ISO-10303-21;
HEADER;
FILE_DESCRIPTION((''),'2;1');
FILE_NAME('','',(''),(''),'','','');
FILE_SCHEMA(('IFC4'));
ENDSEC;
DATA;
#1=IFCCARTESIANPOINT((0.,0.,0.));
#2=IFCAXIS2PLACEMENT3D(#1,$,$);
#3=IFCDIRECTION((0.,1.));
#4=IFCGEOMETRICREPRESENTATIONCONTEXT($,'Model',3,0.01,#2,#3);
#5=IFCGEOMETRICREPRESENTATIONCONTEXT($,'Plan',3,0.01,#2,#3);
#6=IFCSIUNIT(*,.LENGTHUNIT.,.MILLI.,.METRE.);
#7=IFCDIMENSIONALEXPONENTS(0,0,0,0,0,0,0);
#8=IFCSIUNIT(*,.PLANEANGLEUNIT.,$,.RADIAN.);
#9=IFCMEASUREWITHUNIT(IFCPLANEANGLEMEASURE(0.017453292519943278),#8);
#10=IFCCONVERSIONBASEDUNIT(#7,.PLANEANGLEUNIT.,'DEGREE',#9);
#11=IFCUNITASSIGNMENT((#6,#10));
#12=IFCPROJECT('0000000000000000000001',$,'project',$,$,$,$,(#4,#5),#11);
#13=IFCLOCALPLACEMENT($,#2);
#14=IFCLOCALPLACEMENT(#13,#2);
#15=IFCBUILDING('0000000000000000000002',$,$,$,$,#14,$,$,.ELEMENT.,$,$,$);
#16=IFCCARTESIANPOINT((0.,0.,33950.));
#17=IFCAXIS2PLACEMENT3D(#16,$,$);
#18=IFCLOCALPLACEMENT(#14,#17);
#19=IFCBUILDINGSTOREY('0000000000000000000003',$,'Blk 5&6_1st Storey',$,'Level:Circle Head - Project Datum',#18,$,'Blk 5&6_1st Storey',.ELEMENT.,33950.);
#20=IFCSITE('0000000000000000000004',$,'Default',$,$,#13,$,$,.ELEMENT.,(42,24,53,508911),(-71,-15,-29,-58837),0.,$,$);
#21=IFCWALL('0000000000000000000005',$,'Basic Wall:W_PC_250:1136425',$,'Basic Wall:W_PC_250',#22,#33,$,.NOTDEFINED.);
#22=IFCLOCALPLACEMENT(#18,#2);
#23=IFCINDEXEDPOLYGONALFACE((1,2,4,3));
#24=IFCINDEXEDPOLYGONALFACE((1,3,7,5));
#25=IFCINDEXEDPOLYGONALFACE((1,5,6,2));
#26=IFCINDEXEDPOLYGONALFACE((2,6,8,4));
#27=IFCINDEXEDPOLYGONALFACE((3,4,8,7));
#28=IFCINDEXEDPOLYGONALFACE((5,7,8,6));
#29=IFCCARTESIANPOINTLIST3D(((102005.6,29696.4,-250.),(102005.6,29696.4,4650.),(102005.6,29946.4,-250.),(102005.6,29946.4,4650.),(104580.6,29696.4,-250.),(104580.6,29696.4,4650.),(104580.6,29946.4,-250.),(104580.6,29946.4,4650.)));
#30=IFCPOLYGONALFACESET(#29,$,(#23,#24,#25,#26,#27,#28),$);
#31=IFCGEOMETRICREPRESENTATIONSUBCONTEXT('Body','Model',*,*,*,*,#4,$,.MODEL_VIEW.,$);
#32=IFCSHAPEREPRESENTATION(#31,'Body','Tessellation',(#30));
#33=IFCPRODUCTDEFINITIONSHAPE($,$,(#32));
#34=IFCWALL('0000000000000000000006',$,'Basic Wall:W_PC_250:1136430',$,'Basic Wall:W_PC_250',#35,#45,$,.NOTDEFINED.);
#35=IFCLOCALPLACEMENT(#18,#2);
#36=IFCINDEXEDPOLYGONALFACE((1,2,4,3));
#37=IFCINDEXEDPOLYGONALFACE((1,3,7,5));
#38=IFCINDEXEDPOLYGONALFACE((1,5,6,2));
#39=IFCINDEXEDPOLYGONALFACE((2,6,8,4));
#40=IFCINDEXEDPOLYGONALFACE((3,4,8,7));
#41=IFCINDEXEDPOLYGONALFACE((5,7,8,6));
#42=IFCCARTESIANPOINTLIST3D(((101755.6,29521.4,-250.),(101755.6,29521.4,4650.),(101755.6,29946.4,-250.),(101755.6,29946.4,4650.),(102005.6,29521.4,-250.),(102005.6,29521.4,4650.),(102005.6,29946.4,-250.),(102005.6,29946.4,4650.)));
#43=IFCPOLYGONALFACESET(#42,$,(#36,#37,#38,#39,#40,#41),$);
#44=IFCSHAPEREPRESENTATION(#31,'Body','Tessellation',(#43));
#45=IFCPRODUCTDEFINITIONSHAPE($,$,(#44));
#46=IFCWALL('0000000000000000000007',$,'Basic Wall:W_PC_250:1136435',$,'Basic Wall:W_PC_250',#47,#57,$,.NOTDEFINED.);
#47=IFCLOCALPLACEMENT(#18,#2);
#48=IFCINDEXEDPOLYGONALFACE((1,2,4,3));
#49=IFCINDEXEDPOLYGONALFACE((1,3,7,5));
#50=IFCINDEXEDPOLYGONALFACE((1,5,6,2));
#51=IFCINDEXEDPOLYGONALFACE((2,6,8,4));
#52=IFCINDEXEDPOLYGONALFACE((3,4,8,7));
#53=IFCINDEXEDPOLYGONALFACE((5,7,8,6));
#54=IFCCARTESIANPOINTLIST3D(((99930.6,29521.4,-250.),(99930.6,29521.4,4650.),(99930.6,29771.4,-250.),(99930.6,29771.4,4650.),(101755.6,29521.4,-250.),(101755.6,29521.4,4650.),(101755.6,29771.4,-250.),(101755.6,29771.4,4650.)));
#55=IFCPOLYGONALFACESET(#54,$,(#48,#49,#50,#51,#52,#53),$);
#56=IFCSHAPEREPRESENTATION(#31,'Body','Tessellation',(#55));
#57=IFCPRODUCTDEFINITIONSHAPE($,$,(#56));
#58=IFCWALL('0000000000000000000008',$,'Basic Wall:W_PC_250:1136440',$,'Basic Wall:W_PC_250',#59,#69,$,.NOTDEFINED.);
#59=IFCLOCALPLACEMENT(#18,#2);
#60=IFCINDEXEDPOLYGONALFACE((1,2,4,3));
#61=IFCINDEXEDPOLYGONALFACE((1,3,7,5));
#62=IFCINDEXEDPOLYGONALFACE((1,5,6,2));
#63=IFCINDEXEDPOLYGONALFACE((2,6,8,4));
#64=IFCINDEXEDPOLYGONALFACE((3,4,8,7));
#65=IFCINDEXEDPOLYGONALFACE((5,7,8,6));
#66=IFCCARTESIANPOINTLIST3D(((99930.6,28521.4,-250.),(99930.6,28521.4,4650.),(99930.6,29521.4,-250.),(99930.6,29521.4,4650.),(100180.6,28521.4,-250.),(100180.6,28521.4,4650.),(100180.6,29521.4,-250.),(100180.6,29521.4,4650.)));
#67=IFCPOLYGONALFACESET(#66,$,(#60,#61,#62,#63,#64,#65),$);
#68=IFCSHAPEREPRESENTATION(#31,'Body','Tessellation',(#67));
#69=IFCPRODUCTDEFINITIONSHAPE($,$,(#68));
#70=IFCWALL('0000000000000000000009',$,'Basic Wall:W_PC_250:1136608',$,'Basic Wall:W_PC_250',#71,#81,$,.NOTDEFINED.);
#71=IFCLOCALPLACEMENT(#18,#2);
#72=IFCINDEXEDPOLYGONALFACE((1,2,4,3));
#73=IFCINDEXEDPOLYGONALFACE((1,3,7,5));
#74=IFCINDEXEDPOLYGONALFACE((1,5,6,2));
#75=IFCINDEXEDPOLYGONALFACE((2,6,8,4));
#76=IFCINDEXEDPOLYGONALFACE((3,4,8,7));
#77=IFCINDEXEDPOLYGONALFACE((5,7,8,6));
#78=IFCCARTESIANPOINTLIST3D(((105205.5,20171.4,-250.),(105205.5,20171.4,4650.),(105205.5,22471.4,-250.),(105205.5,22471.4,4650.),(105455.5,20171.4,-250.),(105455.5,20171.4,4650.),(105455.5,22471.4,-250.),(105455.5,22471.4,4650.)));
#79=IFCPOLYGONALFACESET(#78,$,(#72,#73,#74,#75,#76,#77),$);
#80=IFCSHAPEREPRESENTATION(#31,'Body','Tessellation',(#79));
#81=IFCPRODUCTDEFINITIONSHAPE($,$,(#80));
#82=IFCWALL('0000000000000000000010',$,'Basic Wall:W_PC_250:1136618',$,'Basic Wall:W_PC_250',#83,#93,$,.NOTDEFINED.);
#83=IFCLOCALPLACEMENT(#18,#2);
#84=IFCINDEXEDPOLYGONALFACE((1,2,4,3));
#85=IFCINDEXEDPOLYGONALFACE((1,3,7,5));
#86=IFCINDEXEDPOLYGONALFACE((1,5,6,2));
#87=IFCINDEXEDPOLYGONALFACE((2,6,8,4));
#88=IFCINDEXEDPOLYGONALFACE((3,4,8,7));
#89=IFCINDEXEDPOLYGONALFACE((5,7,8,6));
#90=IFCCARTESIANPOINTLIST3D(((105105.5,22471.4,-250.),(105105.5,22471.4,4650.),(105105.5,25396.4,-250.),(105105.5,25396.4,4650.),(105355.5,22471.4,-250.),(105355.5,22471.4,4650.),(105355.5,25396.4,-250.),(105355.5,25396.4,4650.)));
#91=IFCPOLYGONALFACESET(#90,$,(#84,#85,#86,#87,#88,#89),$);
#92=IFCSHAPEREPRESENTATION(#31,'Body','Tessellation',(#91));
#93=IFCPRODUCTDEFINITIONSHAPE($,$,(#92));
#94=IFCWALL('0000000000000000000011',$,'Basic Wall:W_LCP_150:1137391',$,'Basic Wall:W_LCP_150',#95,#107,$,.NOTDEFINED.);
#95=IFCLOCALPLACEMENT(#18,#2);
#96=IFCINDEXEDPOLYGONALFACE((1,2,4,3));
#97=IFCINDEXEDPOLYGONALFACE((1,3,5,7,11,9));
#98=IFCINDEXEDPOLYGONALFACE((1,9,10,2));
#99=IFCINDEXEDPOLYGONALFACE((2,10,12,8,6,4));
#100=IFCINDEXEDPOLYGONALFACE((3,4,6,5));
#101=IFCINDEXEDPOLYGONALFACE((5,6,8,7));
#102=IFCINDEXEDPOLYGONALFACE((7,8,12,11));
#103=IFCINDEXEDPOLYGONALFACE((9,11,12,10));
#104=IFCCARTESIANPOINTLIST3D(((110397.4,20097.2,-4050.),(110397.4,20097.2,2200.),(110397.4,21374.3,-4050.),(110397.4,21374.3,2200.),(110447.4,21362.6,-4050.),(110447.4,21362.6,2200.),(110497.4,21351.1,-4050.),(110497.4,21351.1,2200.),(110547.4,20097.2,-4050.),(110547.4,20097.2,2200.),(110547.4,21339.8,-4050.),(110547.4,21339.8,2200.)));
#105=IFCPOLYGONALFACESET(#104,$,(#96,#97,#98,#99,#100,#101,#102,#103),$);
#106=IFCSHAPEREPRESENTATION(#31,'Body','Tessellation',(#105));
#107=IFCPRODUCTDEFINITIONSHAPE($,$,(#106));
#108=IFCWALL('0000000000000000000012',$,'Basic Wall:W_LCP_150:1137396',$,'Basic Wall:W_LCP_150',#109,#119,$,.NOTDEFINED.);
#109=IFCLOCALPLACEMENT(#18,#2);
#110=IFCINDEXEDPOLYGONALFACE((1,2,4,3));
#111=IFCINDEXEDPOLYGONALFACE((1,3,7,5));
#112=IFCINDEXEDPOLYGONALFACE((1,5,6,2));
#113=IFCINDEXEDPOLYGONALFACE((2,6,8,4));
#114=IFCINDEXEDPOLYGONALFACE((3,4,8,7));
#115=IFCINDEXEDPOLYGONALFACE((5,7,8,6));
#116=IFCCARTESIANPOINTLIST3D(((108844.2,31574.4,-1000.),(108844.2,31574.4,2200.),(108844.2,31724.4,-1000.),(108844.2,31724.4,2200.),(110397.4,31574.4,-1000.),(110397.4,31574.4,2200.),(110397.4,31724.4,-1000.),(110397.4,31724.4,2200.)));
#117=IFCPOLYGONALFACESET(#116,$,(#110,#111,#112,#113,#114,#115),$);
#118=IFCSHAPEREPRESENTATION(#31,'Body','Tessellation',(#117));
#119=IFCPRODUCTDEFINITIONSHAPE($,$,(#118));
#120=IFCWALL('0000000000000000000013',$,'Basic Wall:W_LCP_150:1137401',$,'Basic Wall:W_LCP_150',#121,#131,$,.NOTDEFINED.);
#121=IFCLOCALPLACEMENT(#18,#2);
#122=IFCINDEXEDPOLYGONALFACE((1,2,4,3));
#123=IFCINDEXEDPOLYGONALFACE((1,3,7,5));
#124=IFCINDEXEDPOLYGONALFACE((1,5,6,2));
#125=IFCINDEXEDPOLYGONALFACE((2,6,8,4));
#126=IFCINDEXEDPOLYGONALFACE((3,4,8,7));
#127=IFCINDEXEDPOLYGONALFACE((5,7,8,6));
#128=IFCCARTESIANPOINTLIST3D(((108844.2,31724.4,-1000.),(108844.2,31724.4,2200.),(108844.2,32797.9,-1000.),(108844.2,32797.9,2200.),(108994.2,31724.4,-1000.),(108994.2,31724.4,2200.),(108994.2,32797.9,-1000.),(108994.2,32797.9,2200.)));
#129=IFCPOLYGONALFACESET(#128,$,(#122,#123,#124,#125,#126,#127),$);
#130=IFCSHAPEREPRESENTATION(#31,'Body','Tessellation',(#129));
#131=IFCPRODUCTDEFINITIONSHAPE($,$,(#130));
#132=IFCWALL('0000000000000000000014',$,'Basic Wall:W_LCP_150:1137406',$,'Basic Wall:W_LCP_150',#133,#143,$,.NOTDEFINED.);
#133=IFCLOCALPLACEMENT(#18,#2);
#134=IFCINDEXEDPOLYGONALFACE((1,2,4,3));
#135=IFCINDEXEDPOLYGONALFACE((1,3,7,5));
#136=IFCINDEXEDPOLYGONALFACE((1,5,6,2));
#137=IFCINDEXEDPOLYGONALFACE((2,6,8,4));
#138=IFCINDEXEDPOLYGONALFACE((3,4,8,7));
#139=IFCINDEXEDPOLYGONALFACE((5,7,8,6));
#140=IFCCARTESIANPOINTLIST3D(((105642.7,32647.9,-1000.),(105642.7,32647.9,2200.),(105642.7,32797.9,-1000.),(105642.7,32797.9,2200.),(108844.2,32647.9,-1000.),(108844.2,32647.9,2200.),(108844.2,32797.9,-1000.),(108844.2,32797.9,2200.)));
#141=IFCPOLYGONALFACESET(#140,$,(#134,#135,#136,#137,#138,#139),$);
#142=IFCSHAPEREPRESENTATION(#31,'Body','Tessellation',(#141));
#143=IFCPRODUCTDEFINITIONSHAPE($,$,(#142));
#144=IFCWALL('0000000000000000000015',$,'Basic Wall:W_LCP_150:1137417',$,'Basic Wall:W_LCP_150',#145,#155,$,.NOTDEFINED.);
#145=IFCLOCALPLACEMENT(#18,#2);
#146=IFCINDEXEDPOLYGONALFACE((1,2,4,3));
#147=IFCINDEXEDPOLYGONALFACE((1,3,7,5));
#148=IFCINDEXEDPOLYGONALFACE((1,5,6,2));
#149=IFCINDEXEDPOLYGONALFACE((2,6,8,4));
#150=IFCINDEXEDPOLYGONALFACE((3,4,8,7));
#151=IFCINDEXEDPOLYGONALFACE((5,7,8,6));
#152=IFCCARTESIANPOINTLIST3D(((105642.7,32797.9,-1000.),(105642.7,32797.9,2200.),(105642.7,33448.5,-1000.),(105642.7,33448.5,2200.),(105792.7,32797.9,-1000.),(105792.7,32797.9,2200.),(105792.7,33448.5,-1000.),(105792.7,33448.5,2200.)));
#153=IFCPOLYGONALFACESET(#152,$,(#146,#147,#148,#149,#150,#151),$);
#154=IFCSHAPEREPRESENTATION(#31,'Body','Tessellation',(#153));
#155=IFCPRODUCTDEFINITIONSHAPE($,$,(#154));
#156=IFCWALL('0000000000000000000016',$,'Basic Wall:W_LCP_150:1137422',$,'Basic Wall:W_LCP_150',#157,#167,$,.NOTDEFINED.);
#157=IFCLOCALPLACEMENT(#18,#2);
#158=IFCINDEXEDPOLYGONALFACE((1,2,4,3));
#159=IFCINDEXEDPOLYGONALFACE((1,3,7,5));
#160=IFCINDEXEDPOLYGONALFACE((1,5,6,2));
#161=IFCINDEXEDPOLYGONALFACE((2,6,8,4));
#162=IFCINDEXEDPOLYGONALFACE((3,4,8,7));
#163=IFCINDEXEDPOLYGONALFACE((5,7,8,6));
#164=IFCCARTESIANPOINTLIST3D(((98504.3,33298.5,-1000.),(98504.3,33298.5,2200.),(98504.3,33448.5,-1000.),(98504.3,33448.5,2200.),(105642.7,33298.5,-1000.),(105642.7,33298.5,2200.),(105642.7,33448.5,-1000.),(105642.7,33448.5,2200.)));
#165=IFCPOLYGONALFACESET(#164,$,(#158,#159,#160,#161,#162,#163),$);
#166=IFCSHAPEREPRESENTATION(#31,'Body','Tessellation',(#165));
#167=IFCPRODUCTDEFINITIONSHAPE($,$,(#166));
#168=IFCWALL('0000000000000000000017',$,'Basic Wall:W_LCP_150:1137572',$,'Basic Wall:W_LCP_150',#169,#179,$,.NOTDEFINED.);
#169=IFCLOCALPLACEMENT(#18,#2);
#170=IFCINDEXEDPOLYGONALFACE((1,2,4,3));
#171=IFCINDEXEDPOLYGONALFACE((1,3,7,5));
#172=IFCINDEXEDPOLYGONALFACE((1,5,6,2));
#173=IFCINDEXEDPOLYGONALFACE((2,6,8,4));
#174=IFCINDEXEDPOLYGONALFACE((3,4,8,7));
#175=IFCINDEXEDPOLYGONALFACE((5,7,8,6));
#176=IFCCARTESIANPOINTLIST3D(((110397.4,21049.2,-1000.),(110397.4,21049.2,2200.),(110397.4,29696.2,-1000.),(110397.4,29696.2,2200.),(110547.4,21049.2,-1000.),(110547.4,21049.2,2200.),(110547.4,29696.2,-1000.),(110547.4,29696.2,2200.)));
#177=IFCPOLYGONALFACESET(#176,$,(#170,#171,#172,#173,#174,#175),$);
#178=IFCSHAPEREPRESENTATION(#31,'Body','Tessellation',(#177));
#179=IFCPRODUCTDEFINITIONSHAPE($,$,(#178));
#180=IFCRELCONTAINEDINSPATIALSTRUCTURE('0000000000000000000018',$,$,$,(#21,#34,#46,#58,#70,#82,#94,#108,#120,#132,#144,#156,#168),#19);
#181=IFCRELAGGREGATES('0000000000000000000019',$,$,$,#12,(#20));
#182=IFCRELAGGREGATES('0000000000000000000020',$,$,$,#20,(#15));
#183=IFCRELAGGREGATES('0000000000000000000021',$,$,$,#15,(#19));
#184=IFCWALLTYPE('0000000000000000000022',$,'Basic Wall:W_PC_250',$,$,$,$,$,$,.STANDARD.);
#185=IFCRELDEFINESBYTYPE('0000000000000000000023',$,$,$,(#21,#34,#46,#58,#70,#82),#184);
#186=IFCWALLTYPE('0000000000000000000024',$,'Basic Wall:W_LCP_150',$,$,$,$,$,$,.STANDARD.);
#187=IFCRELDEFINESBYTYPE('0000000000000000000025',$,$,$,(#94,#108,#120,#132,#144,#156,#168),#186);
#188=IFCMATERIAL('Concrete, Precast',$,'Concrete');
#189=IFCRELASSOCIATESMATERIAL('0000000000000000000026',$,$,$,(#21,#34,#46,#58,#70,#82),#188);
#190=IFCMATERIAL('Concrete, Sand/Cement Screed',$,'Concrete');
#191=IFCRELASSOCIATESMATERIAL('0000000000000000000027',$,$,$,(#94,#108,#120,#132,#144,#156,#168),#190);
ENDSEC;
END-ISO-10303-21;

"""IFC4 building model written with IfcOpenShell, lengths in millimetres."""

from ifc_helpers import new_model, entity, si_unit, converted_unit, direction, frame, origin, place, context, subcontext, project, spatial, line, arc, indexed_curve, outline, extrude, material, type_object, element, save


model = new_model("IFC4")

# Units and contexts
model_context = context("Model", 3, precision=0.01, world=origin(), true_north=direction((0.0, 1.0)))
plan_context = context("Plan", 3, precision=0.01, world=origin(), true_north=direction((0.0, 1.0)))
body_context = subcontext(model_context, "Body", "Model", "MODEL_VIEW")
ifc_project = project(units=[si_unit("LENGTHUNIT", "METRE", prefix="MILLI"), converted_unit("PLANEANGLEUNIT", "DEGREE", entity("IfcPlaneAngleMeasure", 0.017453292519943278), si_unit("PLANEANGLEUNIT", "RADIAN"), dimensions=[0, 0, 0, 0, 0, 0, 0])], contexts=[model_context, plan_context])

# Site, building, storey
site_placement = place(None, origin())
site = spatial("IfcSite", under=ifc_project, at=site_placement, Name="Default", CompositionType="ELEMENT", RefLatitude=(42, 24, 53, 508911), RefLongitude=(-71, -15, -29, -58837), RefElevation=0.0)
building_placement = place(site_placement, origin())
building = spatial("IfcBuilding", under=site, at=building_placement, CompositionType="ELEMENT")
storey_placement = place(building_placement, frame((0.0, 0.0, 33950.0)))
storey = spatial("IfcBuildingStorey", under=building, at=storey_placement, Name="Blk 5&6_1st Storey", ObjectType="Level:Circle Head - Project Datum", LongName="Blk 5&6_1st Storey", CompositionType="ELEMENT", Elevation=33950.0)

# Walls
ifc_material_1 = material(Name="Concrete, Sand/Cement Screed", Category="Concrete")
ifc_material_2 = material(Name="Concrete, Precast", Category="Concrete")
wall_type_1 = type_object("IfcWallType", Name="Basic Wall:W_PC_250", PredefinedType="STANDARD")
wall_1_placement = place(storey_placement, frame((104580.6, 29821.4, -250.0), z_axis=(0.0, 0.0, 1.0), x_axis=(-1.0, 0.0, 0.0)))
element("IfcWall", 1, at=wall_1_placement, inside=storey, type_object=wall_type_1, material=ifc_material_2, Name="Basic Wall:W_PC_250:1136425", ObjectType="Basic Wall:W_PC_250", PredefinedType="NOTDEFINED", context=body_context, shape_type="SweptSolid", body=[
    extrude(outline(indexed_curve([(2575.0, 125.0), (0.0, 125.0), (0.0, -125.0), (2575.0, -125.0), (2575.0, 125.0)], self_intersect=False)), origin(), (0.0, 0.0, 1.0), 4900.0),
])
wall_2_placement = place(storey_placement, frame((101880.6, 29946.4, -250.0), z_axis=(0.0, 0.0, 1.0), x_axis=(0.0, -1.0, 0.0)))
element("IfcWall", 2, at=wall_2_placement, inside=storey, type_object=wall_type_1, material=ifc_material_2, Name="Basic Wall:W_PC_250:1136430", ObjectType="Basic Wall:W_PC_250", PredefinedType="NOTDEFINED", context=body_context, shape_type="SweptSolid", body=[
    extrude(outline(indexed_curve([(425.0, 125.0), (0.0, 125.0), (0.0, -125.0), (425.0, -125.0), (425.0, 125.0)], self_intersect=False)), origin(), (0.0, 0.0, 1.0), 4900.0),
])
wall_3_placement = place(storey_placement, frame((101755.6, 29646.4, -250.0), z_axis=(0.0, 0.0, 1.0), x_axis=(-1.0, 0.0, 0.0)))
element("IfcWall", 3, at=wall_3_placement, inside=storey, type_object=wall_type_1, material=ifc_material_2, Name="Basic Wall:W_PC_250:1136435", ObjectType="Basic Wall:W_PC_250", PredefinedType="NOTDEFINED", context=body_context, shape_type="SweptSolid", body=[
    extrude(outline(indexed_curve([(1825.0, 125.0), (0.0, 125.0), (0.0, -125.0), (1825.0, -125.0), (1825.0, 125.0)], self_intersect=False)), origin(), (0.0, 0.0, 1.0), 4900.0),
])
wall_4_placement = place(storey_placement, frame((100055.6, 29521.4, -250.0), z_axis=(0.0, 0.0, 1.0), x_axis=(0.0, -1.0, 0.0)))
element("IfcWall", 4, at=wall_4_placement, inside=storey, type_object=wall_type_1, material=ifc_material_2, Name="Basic Wall:W_PC_250:1136440", ObjectType="Basic Wall:W_PC_250", PredefinedType="NOTDEFINED", context=body_context, shape_type="SweptSolid", body=[
    extrude(outline(indexed_curve([(1000.0, 125.0), (0.0, 125.0), (0.0, -125.0), (1000.0, -125.0), (1000.0, 125.0)], self_intersect=False)), origin(), (0.0, 0.0, 1.0), 4900.0),
])
wall_5_placement = place(storey_placement, frame((105330.5, 20171.4, -250.0), z_axis=(0.0, 0.0, 1.0), x_axis=(0.0, 1.0, 0.0)))
element("IfcWall", 5, at=wall_5_placement, inside=storey, type_object=wall_type_1, material=ifc_material_2, Name="Basic Wall:W_PC_250:1136608", ObjectType="Basic Wall:W_PC_250", PredefinedType="NOTDEFINED", context=body_context, shape_type="SweptSolid", body=[
    extrude(outline(indexed_curve([(2300.0, 125.0), (0.0, 125.0), (0.0, -125.0), (2300.0, -125.0), (2300.0, 125.0)], self_intersect=False)), origin(), (0.0, 0.0, 1.0), 4900.0),
])
wall_6_placement = place(storey_placement, frame((105230.5, 22471.4, -250.0), z_axis=(0.0, 0.0, 1.0), x_axis=(0.0, 1.0, 0.0)))
element("IfcWall", 6, at=wall_6_placement, inside=storey, type_object=wall_type_1, material=ifc_material_2, Name="Basic Wall:W_PC_250:1136618", ObjectType="Basic Wall:W_PC_250", PredefinedType="NOTDEFINED", context=body_context, shape_type="SweptSolid", body=[
    extrude(outline(indexed_curve([(2925.0, 125.0), (0.0, 125.0), (0.0, -125.0), (2925.0, -125.0), (2925.0, 125.0)], self_intersect=False)), origin(), (0.0, 0.0, 1.0), 4900.0),
])
wall_type_2 = type_object("IfcWallType", Name="Basic Wall:W_LCP_150", PredefinedType="STANDARD")
wall_7_placement = place(storey_placement, frame((110472.4, 20097.2, -4050.0), z_axis=(0.0, 0.0, 1.0), x_axis=(0.0, 1.0, 0.0)))
element("IfcWall", 7, at=wall_7_placement, inside=storey, type_object=wall_type_2, material=ifc_material_1, Name="Basic Wall:W_LCP_150:1137391", ObjectType="Basic Wall:W_LCP_150", PredefinedType="NOTDEFINED", context=body_context, shape_type="SweptSolid", body=[
    extrude(outline(indexed_curve([(1242.6, -75.0), (1259.6, 0.1), (1277.1, 75.0), (0.0, 75.0), (0.0, -75.0)], segments=[arc(1, 2, 3), line(3, 4, 5, 1)], self_intersect=False)), origin(), (0.0, 0.0, 1.0), 6250.0),
])
wall_8_placement = place(storey_placement, frame((110397.4, 31649.4, -1000.0), z_axis=(0.0, 0.0, 1.0), x_axis=(-1.0, 0.0, 0.0)))
element("IfcWall", 8, at=wall_8_placement, inside=storey, type_object=wall_type_2, material=ifc_material_1, Name="Basic Wall:W_LCP_150:1137396", ObjectType="Basic Wall:W_LCP_150", PredefinedType="NOTDEFINED", context=body_context, shape_type="SweptSolid", body=[
    extrude(outline(indexed_curve([(1553.2, 75.0), (0.0, 75.0), (0.0, -75.0), (1553.2, -75.0), (1553.2, 75.0)], self_intersect=False)), origin(), (0.0, 0.0, 1.0), 3200.0),
])
wall_9_placement = place(storey_placement, frame((108919.2, 31724.4, -1000.0), z_axis=(0.0, 0.0, 1.0), x_axis=(0.0, 1.0, 0.0)))
element("IfcWall", 9, at=wall_9_placement, inside=storey, type_object=wall_type_2, material=ifc_material_1, Name="Basic Wall:W_LCP_150:1137401", ObjectType="Basic Wall:W_LCP_150", PredefinedType="NOTDEFINED", context=body_context, shape_type="SweptSolid", body=[
    extrude(outline(indexed_curve([(1073.5, 75.0), (0.0, 75.0), (0.0, -75.0), (1073.5, -75.0), (1073.5, 75.0)], self_intersect=False)), origin(), (0.0, 0.0, 1.0), 3200.0),
])
wall_10_placement = place(storey_placement, frame((108844.2, 32722.9, -1000.0), z_axis=(0.0, 0.0, 1.0), x_axis=(-1.0, 0.0, 0.0)))
element("IfcWall", 10, at=wall_10_placement, inside=storey, type_object=wall_type_2, material=ifc_material_1, Name="Basic Wall:W_LCP_150:1137406", ObjectType="Basic Wall:W_LCP_150", PredefinedType="NOTDEFINED", context=body_context, shape_type="SweptSolid", body=[
    extrude(outline(indexed_curve([(3201.5, 75.0), (0.0, 75.0), (0.0, -75.0), (3201.5, -75.0), (3201.5, 75.0)], self_intersect=False)), origin(), (0.0, 0.0, 1.0), 3200.0),
])
wall_11_placement = place(storey_placement, frame((105717.7, 32797.9, -1000.0), z_axis=(0.0, 0.0, 1.0), x_axis=(0.0, 1.0, 0.0)))
element("IfcWall", 11, at=wall_11_placement, inside=storey, type_object=wall_type_2, material=ifc_material_1, Name="Basic Wall:W_LCP_150:1137417", ObjectType="Basic Wall:W_LCP_150", PredefinedType="NOTDEFINED", context=body_context, shape_type="SweptSolid", body=[
    extrude(outline(indexed_curve([(650.6, 75.0), (0.0, 75.0), (0.0, -75.0), (650.6, -75.0), (650.6, 75.0)], self_intersect=False)), origin(), (0.0, 0.0, 1.0), 3200.0),
])
wall_12_placement = place(storey_placement, frame((105642.7, 33373.5, -1000.0), z_axis=(0.0, 0.0, 1.0), x_axis=(-1.0, 0.0, 0.0)))
element("IfcWall", 12, at=wall_12_placement, inside=storey, type_object=wall_type_2, material=ifc_material_1, Name="Basic Wall:W_LCP_150:1137422", ObjectType="Basic Wall:W_LCP_150", PredefinedType="NOTDEFINED", context=body_context, shape_type="SweptSolid", body=[
    extrude(outline(indexed_curve([(7138.3, 75.0), (0.0, 75.0), (0.0, -75.0), (7138.3, -75.0), (7138.3, 75.0)], self_intersect=False)), origin(), (0.0, 0.0, 1.0), 3200.0),
])
wall_13_placement = place(storey_placement, frame((110472.4, 21049.2, -1000.0), z_axis=(0.0, 0.0, 1.0), x_axis=(0.0, 1.0, 0.0)))
element("IfcWall", 13, at=wall_13_placement, inside=storey, type_object=wall_type_2, material=ifc_material_1, Name="Basic Wall:W_LCP_150:1137572", ObjectType="Basic Wall:W_LCP_150", PredefinedType="NOTDEFINED", context=body_context, shape_type="SweptSolid", body=[
    extrude(outline(indexed_curve([(8647.1, 75.0), (0.0, 75.0), (0.0, -75.0), (8647.1, -75.0), (8647.1, 75.0)], self_intersect=False)), origin(), (0.0, 0.0, 1.0), 3200.0),
])

save(model, "model.ifc")
